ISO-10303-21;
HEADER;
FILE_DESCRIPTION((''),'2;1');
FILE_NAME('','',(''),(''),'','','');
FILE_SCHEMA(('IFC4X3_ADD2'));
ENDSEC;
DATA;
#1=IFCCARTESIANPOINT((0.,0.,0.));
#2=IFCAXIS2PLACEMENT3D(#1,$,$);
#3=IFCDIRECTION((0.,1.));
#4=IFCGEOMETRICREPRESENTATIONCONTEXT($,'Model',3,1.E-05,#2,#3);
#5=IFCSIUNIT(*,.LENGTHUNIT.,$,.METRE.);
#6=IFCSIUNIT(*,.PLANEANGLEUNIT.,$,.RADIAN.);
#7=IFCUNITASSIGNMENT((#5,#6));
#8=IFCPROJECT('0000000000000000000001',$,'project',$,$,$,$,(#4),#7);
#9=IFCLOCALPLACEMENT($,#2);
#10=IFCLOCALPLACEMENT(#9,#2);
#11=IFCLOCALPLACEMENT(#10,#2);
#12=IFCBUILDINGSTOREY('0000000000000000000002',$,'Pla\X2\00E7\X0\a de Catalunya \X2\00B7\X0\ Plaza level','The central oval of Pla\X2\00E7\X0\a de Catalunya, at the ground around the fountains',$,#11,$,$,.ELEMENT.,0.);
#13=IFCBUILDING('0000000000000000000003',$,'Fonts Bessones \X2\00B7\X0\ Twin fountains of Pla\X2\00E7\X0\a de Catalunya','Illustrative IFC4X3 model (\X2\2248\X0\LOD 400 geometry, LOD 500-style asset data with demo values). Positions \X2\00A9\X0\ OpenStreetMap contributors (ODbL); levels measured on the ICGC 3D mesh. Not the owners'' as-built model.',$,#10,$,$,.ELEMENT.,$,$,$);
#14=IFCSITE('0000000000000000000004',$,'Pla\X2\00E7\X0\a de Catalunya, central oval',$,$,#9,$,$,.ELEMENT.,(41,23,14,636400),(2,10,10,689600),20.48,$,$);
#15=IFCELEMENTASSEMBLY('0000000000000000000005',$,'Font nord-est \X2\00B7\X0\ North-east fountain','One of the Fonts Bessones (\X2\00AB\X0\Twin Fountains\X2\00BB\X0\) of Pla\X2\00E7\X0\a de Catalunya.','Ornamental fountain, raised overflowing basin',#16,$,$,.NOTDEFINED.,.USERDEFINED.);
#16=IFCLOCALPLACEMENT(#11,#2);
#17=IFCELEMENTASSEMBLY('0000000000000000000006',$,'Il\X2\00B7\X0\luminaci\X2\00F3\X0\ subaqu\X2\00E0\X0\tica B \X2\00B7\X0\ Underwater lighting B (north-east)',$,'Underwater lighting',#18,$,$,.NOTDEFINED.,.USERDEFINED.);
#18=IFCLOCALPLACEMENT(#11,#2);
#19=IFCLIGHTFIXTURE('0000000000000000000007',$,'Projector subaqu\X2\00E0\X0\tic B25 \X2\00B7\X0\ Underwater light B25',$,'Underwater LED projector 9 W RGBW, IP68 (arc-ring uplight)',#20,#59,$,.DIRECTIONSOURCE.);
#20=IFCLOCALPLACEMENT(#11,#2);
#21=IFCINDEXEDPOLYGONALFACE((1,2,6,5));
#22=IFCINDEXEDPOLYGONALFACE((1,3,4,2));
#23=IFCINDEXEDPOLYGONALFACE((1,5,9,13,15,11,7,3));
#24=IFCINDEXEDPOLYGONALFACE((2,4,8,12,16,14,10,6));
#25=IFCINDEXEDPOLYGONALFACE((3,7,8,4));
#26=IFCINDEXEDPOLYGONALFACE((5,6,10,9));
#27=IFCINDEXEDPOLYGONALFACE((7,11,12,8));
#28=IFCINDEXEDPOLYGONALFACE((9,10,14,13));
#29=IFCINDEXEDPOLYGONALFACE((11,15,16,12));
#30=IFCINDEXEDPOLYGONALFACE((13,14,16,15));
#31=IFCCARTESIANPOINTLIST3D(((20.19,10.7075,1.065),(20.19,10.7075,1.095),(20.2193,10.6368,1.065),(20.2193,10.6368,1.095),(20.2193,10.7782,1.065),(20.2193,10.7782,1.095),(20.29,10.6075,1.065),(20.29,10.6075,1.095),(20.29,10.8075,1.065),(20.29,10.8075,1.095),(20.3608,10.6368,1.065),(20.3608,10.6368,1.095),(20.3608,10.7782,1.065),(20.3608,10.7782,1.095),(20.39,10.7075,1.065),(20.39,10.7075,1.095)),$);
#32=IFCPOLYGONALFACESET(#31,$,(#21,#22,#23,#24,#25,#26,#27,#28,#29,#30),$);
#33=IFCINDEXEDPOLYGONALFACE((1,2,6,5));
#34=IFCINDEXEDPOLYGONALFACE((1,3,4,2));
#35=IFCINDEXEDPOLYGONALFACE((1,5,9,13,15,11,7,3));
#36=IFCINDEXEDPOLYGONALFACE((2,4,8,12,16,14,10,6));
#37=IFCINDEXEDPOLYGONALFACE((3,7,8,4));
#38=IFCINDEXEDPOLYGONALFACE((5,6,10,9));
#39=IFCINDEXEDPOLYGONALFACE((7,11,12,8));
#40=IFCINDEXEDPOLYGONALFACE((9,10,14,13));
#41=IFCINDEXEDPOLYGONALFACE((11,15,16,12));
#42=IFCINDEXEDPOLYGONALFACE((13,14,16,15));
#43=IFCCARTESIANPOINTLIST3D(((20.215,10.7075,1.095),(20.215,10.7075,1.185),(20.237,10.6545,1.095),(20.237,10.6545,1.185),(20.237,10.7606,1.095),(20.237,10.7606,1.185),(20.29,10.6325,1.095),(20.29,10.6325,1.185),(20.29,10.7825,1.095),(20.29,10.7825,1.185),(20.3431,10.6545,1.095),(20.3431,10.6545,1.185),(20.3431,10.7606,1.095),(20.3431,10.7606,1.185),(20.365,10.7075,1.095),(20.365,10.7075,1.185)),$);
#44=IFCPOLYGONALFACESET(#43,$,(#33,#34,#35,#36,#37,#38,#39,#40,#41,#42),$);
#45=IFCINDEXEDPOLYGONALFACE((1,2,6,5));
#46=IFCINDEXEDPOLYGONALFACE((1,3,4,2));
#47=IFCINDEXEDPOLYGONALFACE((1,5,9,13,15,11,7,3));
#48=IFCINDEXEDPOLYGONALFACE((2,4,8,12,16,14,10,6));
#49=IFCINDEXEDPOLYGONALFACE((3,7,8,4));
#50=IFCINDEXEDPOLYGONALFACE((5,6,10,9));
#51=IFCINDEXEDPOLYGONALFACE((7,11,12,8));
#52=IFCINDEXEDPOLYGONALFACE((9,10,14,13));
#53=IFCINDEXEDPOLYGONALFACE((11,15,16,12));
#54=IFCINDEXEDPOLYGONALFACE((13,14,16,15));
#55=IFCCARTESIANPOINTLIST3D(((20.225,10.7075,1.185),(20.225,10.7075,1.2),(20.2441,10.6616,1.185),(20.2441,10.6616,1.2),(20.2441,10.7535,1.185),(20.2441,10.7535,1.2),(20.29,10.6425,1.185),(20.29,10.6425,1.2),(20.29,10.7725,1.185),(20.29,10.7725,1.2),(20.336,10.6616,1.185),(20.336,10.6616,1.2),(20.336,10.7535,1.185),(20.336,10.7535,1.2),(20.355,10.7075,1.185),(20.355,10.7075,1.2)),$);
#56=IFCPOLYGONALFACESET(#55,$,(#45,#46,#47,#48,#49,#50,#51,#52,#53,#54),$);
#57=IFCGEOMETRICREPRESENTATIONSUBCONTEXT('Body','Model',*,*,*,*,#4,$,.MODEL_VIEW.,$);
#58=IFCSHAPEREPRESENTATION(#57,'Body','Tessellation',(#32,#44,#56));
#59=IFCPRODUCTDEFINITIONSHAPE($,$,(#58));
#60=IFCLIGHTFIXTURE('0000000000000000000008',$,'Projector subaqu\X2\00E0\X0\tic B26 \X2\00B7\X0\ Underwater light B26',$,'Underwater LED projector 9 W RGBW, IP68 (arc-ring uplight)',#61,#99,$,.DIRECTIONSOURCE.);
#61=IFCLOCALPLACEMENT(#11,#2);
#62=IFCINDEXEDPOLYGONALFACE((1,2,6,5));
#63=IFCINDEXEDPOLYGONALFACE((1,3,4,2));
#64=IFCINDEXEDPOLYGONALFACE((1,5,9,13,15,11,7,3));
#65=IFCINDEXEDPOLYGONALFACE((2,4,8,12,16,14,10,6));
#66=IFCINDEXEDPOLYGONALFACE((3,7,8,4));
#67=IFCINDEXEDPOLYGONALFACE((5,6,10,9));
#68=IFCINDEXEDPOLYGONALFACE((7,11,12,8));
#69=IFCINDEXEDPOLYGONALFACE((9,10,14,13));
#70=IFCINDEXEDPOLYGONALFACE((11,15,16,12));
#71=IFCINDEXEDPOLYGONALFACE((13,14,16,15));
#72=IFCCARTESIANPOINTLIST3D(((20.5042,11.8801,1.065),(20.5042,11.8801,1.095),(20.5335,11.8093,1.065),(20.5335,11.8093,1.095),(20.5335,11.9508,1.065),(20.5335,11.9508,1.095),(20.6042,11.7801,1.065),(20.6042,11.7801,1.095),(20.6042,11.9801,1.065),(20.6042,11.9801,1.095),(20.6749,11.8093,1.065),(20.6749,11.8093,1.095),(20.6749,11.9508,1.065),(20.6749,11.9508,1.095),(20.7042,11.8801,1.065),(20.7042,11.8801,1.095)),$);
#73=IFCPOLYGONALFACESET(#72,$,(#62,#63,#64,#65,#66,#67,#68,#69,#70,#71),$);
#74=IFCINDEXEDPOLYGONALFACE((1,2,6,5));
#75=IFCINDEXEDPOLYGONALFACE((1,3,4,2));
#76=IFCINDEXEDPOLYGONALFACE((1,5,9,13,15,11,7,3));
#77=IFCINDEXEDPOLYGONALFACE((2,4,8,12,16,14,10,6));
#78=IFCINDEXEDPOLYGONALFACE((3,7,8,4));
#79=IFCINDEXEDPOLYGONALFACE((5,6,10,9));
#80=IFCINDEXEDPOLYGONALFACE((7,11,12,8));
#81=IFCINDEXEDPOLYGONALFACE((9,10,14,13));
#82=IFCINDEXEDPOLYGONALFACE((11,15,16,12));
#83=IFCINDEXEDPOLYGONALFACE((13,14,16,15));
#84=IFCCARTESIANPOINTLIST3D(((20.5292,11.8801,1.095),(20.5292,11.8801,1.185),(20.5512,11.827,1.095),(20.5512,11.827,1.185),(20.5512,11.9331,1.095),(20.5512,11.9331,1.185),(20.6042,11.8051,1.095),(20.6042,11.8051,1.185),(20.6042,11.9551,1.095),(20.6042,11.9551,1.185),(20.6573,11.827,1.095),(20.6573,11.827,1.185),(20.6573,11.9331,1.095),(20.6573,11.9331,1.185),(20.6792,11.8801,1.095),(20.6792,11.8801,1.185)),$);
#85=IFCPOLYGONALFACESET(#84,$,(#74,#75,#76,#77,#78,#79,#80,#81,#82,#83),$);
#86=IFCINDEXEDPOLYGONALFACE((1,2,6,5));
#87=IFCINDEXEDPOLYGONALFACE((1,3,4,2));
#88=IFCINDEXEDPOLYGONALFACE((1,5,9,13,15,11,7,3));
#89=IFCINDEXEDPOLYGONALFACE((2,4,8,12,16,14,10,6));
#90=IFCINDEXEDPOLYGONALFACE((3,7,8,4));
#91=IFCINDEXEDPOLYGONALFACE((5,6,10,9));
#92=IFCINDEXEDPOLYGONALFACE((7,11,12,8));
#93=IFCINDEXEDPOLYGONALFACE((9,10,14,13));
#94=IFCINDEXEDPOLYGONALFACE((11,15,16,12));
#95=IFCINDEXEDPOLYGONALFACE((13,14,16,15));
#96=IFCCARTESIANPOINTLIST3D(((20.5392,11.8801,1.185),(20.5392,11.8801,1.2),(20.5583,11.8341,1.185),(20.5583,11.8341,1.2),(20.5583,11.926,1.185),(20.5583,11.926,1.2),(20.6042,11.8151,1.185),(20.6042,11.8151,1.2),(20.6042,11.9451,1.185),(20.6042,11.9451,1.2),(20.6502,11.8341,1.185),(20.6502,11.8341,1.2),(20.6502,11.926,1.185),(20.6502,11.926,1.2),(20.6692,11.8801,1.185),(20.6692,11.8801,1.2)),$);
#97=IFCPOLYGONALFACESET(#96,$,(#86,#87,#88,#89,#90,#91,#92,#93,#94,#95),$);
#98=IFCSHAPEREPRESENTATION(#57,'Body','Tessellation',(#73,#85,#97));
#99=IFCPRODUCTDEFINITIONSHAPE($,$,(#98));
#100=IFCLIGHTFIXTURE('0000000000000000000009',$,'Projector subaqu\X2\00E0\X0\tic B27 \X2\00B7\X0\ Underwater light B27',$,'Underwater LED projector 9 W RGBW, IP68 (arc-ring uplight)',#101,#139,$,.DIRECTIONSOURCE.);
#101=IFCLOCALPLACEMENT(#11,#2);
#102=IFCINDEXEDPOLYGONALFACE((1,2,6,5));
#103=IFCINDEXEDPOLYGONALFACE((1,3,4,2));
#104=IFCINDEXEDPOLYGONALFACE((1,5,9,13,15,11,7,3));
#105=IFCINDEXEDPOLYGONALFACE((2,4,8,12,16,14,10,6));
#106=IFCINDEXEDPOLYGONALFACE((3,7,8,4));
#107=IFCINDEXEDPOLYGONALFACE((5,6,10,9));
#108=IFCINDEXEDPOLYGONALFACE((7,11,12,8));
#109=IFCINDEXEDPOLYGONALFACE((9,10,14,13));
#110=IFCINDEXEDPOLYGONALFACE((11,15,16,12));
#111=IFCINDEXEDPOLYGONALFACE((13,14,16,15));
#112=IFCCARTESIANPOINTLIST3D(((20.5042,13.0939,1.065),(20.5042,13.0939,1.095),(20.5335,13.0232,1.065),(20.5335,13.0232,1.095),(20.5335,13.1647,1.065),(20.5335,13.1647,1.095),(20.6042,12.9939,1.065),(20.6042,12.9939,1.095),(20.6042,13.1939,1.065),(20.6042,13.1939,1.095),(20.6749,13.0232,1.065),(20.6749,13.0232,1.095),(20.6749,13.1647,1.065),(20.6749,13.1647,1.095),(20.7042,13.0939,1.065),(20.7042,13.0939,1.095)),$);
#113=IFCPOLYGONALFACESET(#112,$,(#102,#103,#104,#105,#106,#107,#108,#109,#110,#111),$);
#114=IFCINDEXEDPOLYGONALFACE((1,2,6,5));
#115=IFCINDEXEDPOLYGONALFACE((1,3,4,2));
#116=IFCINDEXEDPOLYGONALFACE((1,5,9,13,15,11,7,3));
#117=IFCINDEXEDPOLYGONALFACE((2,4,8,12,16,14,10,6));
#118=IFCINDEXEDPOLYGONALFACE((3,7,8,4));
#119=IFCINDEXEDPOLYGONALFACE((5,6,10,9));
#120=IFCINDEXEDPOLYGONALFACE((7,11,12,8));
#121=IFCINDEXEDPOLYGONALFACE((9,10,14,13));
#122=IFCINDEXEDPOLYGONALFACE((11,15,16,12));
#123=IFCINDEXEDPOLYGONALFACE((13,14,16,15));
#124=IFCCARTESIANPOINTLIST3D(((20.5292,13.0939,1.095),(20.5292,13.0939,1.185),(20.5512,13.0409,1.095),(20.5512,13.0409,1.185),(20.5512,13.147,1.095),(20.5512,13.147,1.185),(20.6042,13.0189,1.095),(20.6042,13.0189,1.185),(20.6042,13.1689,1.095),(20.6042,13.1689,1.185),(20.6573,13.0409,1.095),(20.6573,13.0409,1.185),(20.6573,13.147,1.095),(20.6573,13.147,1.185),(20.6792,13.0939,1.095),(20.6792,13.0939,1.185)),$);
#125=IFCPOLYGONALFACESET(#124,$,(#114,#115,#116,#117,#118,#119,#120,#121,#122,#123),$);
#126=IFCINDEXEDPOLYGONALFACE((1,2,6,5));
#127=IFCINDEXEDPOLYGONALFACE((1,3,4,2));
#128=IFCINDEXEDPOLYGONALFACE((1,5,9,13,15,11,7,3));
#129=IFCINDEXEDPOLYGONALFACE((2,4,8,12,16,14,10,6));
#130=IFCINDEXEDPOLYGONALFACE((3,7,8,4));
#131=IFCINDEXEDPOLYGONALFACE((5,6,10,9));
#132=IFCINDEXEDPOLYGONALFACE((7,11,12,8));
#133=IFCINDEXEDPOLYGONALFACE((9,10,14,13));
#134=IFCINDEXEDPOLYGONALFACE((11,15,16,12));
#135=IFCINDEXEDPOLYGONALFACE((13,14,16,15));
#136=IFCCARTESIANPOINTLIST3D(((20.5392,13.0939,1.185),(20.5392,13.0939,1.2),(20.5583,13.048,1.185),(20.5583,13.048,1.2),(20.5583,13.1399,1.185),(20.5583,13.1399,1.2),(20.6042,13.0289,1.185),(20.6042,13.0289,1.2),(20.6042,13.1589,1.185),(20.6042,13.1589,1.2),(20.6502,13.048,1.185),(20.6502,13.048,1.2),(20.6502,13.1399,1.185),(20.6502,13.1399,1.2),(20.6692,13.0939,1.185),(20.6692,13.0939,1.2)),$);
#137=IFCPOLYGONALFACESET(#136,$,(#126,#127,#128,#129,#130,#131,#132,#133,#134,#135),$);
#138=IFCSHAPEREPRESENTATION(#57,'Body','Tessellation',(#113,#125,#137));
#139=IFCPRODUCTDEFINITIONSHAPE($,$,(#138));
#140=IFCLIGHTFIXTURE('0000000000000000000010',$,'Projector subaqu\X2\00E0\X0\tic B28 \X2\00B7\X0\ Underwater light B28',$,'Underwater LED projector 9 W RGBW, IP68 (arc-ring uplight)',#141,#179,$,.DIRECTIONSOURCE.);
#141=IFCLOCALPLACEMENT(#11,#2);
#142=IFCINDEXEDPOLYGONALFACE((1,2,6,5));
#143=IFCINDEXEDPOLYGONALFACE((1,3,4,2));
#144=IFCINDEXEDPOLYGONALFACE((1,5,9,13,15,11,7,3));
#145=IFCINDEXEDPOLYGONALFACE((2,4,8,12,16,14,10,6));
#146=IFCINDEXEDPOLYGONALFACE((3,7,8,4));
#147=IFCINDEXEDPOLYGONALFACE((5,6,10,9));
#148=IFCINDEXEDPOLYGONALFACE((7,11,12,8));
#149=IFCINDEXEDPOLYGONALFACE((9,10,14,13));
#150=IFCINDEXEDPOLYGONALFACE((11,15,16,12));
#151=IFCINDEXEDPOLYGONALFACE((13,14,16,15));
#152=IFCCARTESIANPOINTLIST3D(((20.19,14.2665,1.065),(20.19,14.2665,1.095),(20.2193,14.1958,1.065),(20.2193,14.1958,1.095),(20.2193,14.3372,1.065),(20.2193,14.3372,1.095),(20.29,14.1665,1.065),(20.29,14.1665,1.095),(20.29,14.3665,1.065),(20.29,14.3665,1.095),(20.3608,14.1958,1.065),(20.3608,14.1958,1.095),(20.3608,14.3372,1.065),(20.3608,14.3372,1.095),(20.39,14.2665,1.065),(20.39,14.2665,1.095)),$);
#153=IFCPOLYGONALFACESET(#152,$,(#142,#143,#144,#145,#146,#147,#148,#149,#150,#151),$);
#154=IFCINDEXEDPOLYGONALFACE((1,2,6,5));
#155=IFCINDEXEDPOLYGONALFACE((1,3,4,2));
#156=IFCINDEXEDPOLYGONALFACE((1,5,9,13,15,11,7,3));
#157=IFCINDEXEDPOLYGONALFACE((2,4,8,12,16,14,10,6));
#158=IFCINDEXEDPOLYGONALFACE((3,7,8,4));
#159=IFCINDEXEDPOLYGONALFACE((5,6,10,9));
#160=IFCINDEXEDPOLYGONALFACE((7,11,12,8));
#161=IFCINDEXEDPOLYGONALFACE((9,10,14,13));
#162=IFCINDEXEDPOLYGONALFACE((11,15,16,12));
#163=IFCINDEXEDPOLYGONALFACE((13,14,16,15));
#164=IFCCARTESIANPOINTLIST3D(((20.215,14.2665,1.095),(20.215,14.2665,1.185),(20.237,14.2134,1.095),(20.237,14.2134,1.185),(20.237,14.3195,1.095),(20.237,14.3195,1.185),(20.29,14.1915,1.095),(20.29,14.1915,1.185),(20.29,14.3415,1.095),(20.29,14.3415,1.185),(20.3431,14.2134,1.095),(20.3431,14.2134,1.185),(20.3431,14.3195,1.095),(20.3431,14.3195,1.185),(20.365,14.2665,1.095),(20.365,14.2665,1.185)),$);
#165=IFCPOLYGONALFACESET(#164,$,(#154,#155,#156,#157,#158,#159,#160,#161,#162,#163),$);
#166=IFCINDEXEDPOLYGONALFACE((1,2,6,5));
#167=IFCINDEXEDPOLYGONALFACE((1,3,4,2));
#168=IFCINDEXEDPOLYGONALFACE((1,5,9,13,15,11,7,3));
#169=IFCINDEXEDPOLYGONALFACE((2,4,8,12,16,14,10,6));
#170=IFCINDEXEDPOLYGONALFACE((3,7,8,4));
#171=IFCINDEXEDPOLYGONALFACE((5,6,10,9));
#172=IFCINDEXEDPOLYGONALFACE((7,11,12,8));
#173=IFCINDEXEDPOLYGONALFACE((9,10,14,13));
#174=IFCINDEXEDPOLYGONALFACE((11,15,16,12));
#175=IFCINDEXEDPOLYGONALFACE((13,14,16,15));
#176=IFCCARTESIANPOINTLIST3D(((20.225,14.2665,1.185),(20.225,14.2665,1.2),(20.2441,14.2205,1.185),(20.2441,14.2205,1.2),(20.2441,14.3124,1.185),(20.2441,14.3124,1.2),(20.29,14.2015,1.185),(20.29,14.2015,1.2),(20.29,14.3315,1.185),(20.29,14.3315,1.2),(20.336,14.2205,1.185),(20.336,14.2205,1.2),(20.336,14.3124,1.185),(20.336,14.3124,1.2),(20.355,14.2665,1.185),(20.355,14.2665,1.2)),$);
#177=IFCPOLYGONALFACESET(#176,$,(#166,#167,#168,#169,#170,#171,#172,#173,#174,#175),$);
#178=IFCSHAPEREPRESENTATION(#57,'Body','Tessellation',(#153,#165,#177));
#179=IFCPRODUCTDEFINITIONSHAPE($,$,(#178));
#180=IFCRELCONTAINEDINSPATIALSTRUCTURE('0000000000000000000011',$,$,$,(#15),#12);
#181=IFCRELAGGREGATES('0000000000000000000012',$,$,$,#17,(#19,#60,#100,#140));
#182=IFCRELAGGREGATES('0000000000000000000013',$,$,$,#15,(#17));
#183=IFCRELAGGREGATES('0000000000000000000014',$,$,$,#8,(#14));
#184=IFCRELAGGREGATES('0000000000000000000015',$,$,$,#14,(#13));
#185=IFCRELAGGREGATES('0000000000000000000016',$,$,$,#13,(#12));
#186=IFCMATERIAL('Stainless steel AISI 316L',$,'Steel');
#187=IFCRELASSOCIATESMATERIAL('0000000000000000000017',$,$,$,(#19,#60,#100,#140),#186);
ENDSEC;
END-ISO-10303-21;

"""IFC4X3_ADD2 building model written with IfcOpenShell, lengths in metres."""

from ifc_helpers import new_model, si_unit, direction, frame, origin, place, context, subcontext, project, spatial, polyline, outline, extrude, material, element, aggregate, save


model = new_model("IFC4X3_ADD2")

# Units and contexts
model_context = context("Model", 3, precision=1e-05, world=origin(), true_north=direction((0.0, 1.0)))
body_context = subcontext(model_context, "Body", "Model", "MODEL_VIEW")
ifc_project = project(units=[si_unit("LENGTHUNIT", "METRE"), si_unit("PLANEANGLEUNIT", "RADIAN")], contexts=[model_context])

# Site, building, storey
site_placement = place(None, origin())
site = spatial("IfcSite", under=ifc_project, at=site_placement, Name="Plaça de Catalunya, central oval", CompositionType="ELEMENT", RefLatitude=(41, 23, 14, 636400), RefLongitude=(2, 10, 10, 689600), RefElevation=20.48)
building_placement = place(site_placement, origin())
building = spatial("IfcBuilding", under=site, at=building_placement, Name="Fonts Bessones · Twin fountains of Plaça de Catalunya", Description="Illustrative IFC4X3 model (≈LOD 400 geometry, LOD 500-style asset data with demo values). Positions © OpenStreetMap contributors (ODbL); levels measured on the ICGC 3D mesh. Not the owners' as-built model.", CompositionType="ELEMENT")
storey_placement = place(building_placement, origin())
storey = spatial("IfcBuildingStorey", under=building, at=storey_placement, Name="Plaça de Catalunya · Plaza level", Description="The central oval of Plaça de Catalunya, at the ground around the fountains", CompositionType="ELEMENT", Elevation=0.0)

# Element assemblies, light fixtures
assembly_1_placement = place(building_placement, origin())
assembly_1 = element("IfcElementAssembly", 1, at=assembly_1_placement, inside=storey, Name="Font nord-est · North-east fountain", Description="One of the Fonts Bessones («Twin Fountains») of Plaça de Catalunya.", ObjectType="Ornamental fountain, raised overflowing basin", AssemblyPlace="NOTDEFINED", PredefinedType="USERDEFINED")
assembly_2_placement = place(building_placement, origin())
assembly_2 = element("IfcElementAssembly", 2, at=assembly_2_placement, Name="Il·luminació subaquàtica B · Underwater lighting B (north-east)", ObjectType="Underwater lighting", AssemblyPlace="NOTDEFINED", PredefinedType="USERDEFINED")
ifc_material_1 = material(Name="Stainless steel AISI 316L", Category="Steel")
light_fixture_1_placement = place(building_placement, origin())
light_fixture_1 = element("IfcLightFixture", 3, at=light_fixture_1_placement, material=ifc_material_1, Name="Projector subaquàtic B25 · Underwater light B25", ObjectType="Underwater LED projector 9 W RGBW, IP68 (arc-ring uplight)", PredefinedType="DIRECTIONSOURCE", context=body_context, shape_type="SweptSolid", body=[
    extrude(outline(polyline([(20.39, 10.7075), (20.3608, 10.7782), (20.29, 10.8075), (20.2193, 10.7782), (20.19, 10.7075), (20.2193, 10.6368), (20.29, 10.6075), (20.3608, 10.6368), (20.39, 10.7075)])), frame((0.0, 0.0, 1.065)), (0.0, 0.0, 1.0), 0.03),
    extrude(outline(polyline([(20.365, 10.7075), (20.3431, 10.7606), (20.29, 10.7825), (20.237, 10.7606), (20.215, 10.7075), (20.237, 10.6545), (20.29, 10.6325), (20.3431, 10.6545), (20.365, 10.7075)])), frame((0.0, 0.0, 1.095)), (0.0, 0.0, 1.0), 0.09),
    extrude(outline(polyline([(20.355, 10.7075), (20.336, 10.7535), (20.29, 10.7725), (20.2441, 10.7535), (20.225, 10.7075), (20.2441, 10.6616), (20.29, 10.6425), (20.336, 10.6616), (20.355, 10.7075)])), frame((0.0, 0.0, 1.185)), (0.0, 0.0, 1.0), 0.015),
])
light_fixture_2_placement = place(building_placement, origin())
light_fixture_2 = element("IfcLightFixture", 4, at=light_fixture_2_placement, material=ifc_material_1, Name="Projector subaquàtic B26 · Underwater light B26", ObjectType="Underwater LED projector 9 W RGBW, IP68 (arc-ring uplight)", PredefinedType="DIRECTIONSOURCE", context=body_context, shape_type="SweptSolid", body=[
    extrude(outline(polyline([(20.7042, 11.8801), (20.6749, 11.9508), (20.6042, 11.9801), (20.5335, 11.9508), (20.5042, 11.8801), (20.5335, 11.8093), (20.6042, 11.7801), (20.6749, 11.8093), (20.7042, 11.8801)])), frame((0.0, 0.0, 1.065)), (0.0, 0.0, 1.0), 0.03),
    extrude(outline(polyline([(20.6792, 11.8801), (20.6573, 11.9331), (20.6042, 11.9551), (20.5512, 11.9331), (20.5292, 11.8801), (20.5512, 11.827), (20.6042, 11.8051), (20.6573, 11.827), (20.6792, 11.8801)])), frame((0.0, 0.0, 1.095)), (0.0, 0.0, 1.0), 0.09),
    extrude(outline(polyline([(20.6692, 11.8801), (20.6502, 11.926), (20.6042, 11.9451), (20.5583, 11.926), (20.5392, 11.8801), (20.5583, 11.8341), (20.6042, 11.8151), (20.6502, 11.8341), (20.6692, 11.8801)])), frame((0.0, 0.0, 1.185)), (0.0, 0.0, 1.0), 0.015),
])
light_fixture_3_placement = place(building_placement, origin())
light_fixture_3 = element("IfcLightFixture", 5, at=light_fixture_3_placement, material=ifc_material_1, Name="Projector subaquàtic B27 · Underwater light B27", ObjectType="Underwater LED projector 9 W RGBW, IP68 (arc-ring uplight)", PredefinedType="DIRECTIONSOURCE", context=body_context, shape_type="SweptSolid", body=[
    extrude(outline(polyline([(20.7042, 13.0939), (20.6749, 13.1647), (20.6042, 13.1939), (20.5335, 13.1647), (20.5042, 13.0939), (20.5335, 13.0232), (20.6042, 12.9939), (20.6749, 13.0232), (20.7042, 13.0939)])), frame((0.0, 0.0, 1.065)), (0.0, 0.0, 1.0), 0.03),
    extrude(outline(polyline([(20.6792, 13.0939), (20.6573, 13.147), (20.6042, 13.1689), (20.5512, 13.147), (20.5292, 13.0939), (20.5512, 13.0409), (20.6042, 13.0189), (20.6573, 13.0409), (20.6792, 13.0939)])), frame((0.0, 0.0, 1.095)), (0.0, 0.0, 1.0), 0.09),
    extrude(outline(polyline([(20.6692, 13.0939), (20.6502, 13.1399), (20.6042, 13.1589), (20.5583, 13.1399), (20.5392, 13.0939), (20.5583, 13.048), (20.6042, 13.0289), (20.6502, 13.048), (20.6692, 13.0939)])), frame((0.0, 0.0, 1.185)), (0.0, 0.0, 1.0), 0.015),
])
light_fixture_4_placement = place(building_placement, origin())
light_fixture_4 = element("IfcLightFixture", 6, at=light_fixture_4_placement, material=ifc_material_1, Name="Projector subaquàtic B28 · Underwater light B28", ObjectType="Underwater LED projector 9 W RGBW, IP68 (arc-ring uplight)", PredefinedType="DIRECTIONSOURCE", context=body_context, shape_type="SweptSolid", body=[
    extrude(outline(polyline([(20.39, 14.2665), (20.3608, 14.3372), (20.29, 14.3665), (20.2193, 14.3372), (20.19, 14.2665), (20.2193, 14.1958), (20.29, 14.1665), (20.3608, 14.1958), (20.39, 14.2665)])), frame((0.0, 0.0, 1.065)), (0.0, 0.0, 1.0), 0.03),
    extrude(outline(polyline([(20.365, 14.2665), (20.3431, 14.3195), (20.29, 14.3415), (20.237, 14.3195), (20.215, 14.2665), (20.237, 14.2134), (20.29, 14.1915), (20.3431, 14.2134), (20.365, 14.2665)])), frame((0.0, 0.0, 1.095)), (0.0, 0.0, 1.0), 0.09),
    extrude(outline(polyline([(20.355, 14.2665), (20.336, 14.3124), (20.29, 14.3315), (20.2441, 14.3124), (20.225, 14.2665), (20.2441, 14.2205), (20.29, 14.2015), (20.336, 14.2205), (20.355, 14.2665)])), frame((0.0, 0.0, 1.185)), (0.0, 0.0, 1.0), 0.015),
])
aggregate(assembly_2, [light_fixture_1, light_fixture_2, light_fixture_3, light_fixture_4])
aggregate(assembly_1, [assembly_2])

save(model, "model.ifc")
